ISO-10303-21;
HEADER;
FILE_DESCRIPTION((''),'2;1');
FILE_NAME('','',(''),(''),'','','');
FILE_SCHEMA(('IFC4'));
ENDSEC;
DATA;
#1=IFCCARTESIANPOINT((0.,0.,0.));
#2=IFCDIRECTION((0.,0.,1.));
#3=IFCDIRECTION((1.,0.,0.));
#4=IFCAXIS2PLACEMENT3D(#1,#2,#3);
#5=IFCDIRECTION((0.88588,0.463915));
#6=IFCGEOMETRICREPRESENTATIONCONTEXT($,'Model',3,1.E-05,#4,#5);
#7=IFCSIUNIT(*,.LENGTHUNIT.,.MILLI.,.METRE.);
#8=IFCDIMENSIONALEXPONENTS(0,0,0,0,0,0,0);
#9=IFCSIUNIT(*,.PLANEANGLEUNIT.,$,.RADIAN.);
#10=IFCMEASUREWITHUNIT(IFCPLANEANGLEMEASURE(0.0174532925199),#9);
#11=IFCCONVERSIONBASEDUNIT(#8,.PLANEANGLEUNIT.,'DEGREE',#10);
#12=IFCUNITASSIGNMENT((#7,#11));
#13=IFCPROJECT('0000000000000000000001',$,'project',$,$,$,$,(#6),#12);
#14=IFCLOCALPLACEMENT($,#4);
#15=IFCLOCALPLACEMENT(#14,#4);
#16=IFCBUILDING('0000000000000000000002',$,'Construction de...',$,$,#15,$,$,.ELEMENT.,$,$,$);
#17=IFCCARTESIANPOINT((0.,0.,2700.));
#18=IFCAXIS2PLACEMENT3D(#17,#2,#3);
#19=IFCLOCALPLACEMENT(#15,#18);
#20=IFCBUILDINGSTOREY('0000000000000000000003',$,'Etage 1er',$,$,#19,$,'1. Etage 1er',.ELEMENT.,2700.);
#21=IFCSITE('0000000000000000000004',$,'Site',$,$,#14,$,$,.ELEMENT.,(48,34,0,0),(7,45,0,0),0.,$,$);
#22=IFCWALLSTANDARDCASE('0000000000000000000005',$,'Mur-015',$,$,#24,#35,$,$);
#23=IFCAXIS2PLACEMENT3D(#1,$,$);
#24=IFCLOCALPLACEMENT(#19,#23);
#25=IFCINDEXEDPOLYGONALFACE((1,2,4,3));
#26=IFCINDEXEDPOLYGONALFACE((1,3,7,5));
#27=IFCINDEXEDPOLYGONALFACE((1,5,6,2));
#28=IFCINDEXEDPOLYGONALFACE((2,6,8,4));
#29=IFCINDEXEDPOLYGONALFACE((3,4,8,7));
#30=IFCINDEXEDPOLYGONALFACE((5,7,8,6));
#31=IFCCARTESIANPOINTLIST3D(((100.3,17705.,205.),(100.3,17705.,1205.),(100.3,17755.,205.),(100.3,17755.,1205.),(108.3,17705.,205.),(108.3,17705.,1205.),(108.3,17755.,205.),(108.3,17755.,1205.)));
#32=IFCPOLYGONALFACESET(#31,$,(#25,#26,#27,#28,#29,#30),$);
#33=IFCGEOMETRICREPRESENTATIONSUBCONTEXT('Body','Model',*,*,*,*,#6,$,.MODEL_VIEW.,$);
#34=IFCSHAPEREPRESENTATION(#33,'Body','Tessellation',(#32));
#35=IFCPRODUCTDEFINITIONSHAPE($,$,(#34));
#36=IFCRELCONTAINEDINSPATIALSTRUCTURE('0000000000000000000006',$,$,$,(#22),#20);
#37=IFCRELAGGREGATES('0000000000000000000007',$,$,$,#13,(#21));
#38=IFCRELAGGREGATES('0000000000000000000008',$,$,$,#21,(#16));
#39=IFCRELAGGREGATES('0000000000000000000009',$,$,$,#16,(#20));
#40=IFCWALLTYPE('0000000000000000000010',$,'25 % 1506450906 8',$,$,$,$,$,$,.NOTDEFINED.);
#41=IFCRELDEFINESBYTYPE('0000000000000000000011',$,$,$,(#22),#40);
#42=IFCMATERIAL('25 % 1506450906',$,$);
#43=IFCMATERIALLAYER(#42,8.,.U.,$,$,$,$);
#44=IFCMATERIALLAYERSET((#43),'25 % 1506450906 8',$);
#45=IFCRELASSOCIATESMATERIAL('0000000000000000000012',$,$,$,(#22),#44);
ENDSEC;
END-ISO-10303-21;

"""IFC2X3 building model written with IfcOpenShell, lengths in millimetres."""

from ifc_helpers import new_model, entity, si_unit, converted_unit, direction, frame, origin_with_axes, place, context, subcontext, project, spatial, polyline, outline, extrude, material, layer, layer_set, layer_usage, type_object, element, save


model = new_model("IFC2X3")

# Units and contexts
model_context = context("Model", 3, precision=1e-05, world=origin_with_axes(), true_north=direction((0.88588, 0.463915)))
body_context = subcontext(model_context, "Body", "Model", "MODEL_VIEW")
ifc_project = project(units=[si_unit("LENGTHUNIT", "METRE", prefix="MILLI"), converted_unit("PLANEANGLEUNIT", "DEGREE", entity("IfcPlaneAngleMeasure", 0.0174532925199), si_unit("PLANEANGLEUNIT", "RADIAN"), dimensions=[0, 0, 0, 0, 0, 0, 0])], contexts=[model_context])

# Site, building, storey
site_placement = place(None, origin_with_axes())
site = spatial("IfcSite", under=ifc_project, at=site_placement, Name="Site", CompositionType="ELEMENT", RefLatitude=(48, 34, 0, 0), RefLongitude=(7, 45, 0, 0), RefElevation=0.0)
building_placement = place(site_placement, origin_with_axes())
building = spatial("IfcBuilding", under=site, at=building_placement, Name="Construction de...", CompositionType="ELEMENT")
storey_placement = place(building_placement, frame((0.0, 0.0, 2700.0), z_axis=(0.0, 0.0, 1.0), x_axis=(1.0, 0.0, 0.0)))
storey = spatial("IfcBuildingStorey", under=building, at=storey_placement, Name="Etage 1er", LongName="1. Etage 1er", CompositionType="ELEMENT", Elevation=2700.0)

# Shared definitions
ifc_material_1 = material(Name="25 % 1506450906")

# Wall
ifc_layer_1 = layer(ifc_material_1, 8.0, ventilated="UNKNOWN")
ifc_layer_set_1 = layer_set([ifc_layer_1], Name="25 % 1506450906 8")
ifc_layer_usage_1 = layer_usage(ifc_layer_set_1, "AXIS2", "NEGATIVE", 4.0)
wall_type_1 = type_object("IfcWallType", Name="25 % 1506450906 8", PredefinedType="NOTDEFINED")
wall_1_placement = place(storey_placement, frame((104.3, 17755.0, 205.0), z_axis=(0.0, 0.0, 1.0), x_axis=(0.0, -1.0, 0.0)))
element("IfcWallStandardCase", 1, at=wall_1_placement, inside=storey, type_object=wall_type_1, material=ifc_layer_usage_1, Name="Mur-015", context=body_context, shape_type="SweptSolid", body=[
    extrude(outline(polyline([(0.0, -4.0), (50.0, -4.0), (50.0, 4.0), (0.0, 4.0), (0.0, -4.0)])), origin_with_axes(), (0.0, 0.0, 1.0), 1000.0),
])

save(model, "model.ifc")
